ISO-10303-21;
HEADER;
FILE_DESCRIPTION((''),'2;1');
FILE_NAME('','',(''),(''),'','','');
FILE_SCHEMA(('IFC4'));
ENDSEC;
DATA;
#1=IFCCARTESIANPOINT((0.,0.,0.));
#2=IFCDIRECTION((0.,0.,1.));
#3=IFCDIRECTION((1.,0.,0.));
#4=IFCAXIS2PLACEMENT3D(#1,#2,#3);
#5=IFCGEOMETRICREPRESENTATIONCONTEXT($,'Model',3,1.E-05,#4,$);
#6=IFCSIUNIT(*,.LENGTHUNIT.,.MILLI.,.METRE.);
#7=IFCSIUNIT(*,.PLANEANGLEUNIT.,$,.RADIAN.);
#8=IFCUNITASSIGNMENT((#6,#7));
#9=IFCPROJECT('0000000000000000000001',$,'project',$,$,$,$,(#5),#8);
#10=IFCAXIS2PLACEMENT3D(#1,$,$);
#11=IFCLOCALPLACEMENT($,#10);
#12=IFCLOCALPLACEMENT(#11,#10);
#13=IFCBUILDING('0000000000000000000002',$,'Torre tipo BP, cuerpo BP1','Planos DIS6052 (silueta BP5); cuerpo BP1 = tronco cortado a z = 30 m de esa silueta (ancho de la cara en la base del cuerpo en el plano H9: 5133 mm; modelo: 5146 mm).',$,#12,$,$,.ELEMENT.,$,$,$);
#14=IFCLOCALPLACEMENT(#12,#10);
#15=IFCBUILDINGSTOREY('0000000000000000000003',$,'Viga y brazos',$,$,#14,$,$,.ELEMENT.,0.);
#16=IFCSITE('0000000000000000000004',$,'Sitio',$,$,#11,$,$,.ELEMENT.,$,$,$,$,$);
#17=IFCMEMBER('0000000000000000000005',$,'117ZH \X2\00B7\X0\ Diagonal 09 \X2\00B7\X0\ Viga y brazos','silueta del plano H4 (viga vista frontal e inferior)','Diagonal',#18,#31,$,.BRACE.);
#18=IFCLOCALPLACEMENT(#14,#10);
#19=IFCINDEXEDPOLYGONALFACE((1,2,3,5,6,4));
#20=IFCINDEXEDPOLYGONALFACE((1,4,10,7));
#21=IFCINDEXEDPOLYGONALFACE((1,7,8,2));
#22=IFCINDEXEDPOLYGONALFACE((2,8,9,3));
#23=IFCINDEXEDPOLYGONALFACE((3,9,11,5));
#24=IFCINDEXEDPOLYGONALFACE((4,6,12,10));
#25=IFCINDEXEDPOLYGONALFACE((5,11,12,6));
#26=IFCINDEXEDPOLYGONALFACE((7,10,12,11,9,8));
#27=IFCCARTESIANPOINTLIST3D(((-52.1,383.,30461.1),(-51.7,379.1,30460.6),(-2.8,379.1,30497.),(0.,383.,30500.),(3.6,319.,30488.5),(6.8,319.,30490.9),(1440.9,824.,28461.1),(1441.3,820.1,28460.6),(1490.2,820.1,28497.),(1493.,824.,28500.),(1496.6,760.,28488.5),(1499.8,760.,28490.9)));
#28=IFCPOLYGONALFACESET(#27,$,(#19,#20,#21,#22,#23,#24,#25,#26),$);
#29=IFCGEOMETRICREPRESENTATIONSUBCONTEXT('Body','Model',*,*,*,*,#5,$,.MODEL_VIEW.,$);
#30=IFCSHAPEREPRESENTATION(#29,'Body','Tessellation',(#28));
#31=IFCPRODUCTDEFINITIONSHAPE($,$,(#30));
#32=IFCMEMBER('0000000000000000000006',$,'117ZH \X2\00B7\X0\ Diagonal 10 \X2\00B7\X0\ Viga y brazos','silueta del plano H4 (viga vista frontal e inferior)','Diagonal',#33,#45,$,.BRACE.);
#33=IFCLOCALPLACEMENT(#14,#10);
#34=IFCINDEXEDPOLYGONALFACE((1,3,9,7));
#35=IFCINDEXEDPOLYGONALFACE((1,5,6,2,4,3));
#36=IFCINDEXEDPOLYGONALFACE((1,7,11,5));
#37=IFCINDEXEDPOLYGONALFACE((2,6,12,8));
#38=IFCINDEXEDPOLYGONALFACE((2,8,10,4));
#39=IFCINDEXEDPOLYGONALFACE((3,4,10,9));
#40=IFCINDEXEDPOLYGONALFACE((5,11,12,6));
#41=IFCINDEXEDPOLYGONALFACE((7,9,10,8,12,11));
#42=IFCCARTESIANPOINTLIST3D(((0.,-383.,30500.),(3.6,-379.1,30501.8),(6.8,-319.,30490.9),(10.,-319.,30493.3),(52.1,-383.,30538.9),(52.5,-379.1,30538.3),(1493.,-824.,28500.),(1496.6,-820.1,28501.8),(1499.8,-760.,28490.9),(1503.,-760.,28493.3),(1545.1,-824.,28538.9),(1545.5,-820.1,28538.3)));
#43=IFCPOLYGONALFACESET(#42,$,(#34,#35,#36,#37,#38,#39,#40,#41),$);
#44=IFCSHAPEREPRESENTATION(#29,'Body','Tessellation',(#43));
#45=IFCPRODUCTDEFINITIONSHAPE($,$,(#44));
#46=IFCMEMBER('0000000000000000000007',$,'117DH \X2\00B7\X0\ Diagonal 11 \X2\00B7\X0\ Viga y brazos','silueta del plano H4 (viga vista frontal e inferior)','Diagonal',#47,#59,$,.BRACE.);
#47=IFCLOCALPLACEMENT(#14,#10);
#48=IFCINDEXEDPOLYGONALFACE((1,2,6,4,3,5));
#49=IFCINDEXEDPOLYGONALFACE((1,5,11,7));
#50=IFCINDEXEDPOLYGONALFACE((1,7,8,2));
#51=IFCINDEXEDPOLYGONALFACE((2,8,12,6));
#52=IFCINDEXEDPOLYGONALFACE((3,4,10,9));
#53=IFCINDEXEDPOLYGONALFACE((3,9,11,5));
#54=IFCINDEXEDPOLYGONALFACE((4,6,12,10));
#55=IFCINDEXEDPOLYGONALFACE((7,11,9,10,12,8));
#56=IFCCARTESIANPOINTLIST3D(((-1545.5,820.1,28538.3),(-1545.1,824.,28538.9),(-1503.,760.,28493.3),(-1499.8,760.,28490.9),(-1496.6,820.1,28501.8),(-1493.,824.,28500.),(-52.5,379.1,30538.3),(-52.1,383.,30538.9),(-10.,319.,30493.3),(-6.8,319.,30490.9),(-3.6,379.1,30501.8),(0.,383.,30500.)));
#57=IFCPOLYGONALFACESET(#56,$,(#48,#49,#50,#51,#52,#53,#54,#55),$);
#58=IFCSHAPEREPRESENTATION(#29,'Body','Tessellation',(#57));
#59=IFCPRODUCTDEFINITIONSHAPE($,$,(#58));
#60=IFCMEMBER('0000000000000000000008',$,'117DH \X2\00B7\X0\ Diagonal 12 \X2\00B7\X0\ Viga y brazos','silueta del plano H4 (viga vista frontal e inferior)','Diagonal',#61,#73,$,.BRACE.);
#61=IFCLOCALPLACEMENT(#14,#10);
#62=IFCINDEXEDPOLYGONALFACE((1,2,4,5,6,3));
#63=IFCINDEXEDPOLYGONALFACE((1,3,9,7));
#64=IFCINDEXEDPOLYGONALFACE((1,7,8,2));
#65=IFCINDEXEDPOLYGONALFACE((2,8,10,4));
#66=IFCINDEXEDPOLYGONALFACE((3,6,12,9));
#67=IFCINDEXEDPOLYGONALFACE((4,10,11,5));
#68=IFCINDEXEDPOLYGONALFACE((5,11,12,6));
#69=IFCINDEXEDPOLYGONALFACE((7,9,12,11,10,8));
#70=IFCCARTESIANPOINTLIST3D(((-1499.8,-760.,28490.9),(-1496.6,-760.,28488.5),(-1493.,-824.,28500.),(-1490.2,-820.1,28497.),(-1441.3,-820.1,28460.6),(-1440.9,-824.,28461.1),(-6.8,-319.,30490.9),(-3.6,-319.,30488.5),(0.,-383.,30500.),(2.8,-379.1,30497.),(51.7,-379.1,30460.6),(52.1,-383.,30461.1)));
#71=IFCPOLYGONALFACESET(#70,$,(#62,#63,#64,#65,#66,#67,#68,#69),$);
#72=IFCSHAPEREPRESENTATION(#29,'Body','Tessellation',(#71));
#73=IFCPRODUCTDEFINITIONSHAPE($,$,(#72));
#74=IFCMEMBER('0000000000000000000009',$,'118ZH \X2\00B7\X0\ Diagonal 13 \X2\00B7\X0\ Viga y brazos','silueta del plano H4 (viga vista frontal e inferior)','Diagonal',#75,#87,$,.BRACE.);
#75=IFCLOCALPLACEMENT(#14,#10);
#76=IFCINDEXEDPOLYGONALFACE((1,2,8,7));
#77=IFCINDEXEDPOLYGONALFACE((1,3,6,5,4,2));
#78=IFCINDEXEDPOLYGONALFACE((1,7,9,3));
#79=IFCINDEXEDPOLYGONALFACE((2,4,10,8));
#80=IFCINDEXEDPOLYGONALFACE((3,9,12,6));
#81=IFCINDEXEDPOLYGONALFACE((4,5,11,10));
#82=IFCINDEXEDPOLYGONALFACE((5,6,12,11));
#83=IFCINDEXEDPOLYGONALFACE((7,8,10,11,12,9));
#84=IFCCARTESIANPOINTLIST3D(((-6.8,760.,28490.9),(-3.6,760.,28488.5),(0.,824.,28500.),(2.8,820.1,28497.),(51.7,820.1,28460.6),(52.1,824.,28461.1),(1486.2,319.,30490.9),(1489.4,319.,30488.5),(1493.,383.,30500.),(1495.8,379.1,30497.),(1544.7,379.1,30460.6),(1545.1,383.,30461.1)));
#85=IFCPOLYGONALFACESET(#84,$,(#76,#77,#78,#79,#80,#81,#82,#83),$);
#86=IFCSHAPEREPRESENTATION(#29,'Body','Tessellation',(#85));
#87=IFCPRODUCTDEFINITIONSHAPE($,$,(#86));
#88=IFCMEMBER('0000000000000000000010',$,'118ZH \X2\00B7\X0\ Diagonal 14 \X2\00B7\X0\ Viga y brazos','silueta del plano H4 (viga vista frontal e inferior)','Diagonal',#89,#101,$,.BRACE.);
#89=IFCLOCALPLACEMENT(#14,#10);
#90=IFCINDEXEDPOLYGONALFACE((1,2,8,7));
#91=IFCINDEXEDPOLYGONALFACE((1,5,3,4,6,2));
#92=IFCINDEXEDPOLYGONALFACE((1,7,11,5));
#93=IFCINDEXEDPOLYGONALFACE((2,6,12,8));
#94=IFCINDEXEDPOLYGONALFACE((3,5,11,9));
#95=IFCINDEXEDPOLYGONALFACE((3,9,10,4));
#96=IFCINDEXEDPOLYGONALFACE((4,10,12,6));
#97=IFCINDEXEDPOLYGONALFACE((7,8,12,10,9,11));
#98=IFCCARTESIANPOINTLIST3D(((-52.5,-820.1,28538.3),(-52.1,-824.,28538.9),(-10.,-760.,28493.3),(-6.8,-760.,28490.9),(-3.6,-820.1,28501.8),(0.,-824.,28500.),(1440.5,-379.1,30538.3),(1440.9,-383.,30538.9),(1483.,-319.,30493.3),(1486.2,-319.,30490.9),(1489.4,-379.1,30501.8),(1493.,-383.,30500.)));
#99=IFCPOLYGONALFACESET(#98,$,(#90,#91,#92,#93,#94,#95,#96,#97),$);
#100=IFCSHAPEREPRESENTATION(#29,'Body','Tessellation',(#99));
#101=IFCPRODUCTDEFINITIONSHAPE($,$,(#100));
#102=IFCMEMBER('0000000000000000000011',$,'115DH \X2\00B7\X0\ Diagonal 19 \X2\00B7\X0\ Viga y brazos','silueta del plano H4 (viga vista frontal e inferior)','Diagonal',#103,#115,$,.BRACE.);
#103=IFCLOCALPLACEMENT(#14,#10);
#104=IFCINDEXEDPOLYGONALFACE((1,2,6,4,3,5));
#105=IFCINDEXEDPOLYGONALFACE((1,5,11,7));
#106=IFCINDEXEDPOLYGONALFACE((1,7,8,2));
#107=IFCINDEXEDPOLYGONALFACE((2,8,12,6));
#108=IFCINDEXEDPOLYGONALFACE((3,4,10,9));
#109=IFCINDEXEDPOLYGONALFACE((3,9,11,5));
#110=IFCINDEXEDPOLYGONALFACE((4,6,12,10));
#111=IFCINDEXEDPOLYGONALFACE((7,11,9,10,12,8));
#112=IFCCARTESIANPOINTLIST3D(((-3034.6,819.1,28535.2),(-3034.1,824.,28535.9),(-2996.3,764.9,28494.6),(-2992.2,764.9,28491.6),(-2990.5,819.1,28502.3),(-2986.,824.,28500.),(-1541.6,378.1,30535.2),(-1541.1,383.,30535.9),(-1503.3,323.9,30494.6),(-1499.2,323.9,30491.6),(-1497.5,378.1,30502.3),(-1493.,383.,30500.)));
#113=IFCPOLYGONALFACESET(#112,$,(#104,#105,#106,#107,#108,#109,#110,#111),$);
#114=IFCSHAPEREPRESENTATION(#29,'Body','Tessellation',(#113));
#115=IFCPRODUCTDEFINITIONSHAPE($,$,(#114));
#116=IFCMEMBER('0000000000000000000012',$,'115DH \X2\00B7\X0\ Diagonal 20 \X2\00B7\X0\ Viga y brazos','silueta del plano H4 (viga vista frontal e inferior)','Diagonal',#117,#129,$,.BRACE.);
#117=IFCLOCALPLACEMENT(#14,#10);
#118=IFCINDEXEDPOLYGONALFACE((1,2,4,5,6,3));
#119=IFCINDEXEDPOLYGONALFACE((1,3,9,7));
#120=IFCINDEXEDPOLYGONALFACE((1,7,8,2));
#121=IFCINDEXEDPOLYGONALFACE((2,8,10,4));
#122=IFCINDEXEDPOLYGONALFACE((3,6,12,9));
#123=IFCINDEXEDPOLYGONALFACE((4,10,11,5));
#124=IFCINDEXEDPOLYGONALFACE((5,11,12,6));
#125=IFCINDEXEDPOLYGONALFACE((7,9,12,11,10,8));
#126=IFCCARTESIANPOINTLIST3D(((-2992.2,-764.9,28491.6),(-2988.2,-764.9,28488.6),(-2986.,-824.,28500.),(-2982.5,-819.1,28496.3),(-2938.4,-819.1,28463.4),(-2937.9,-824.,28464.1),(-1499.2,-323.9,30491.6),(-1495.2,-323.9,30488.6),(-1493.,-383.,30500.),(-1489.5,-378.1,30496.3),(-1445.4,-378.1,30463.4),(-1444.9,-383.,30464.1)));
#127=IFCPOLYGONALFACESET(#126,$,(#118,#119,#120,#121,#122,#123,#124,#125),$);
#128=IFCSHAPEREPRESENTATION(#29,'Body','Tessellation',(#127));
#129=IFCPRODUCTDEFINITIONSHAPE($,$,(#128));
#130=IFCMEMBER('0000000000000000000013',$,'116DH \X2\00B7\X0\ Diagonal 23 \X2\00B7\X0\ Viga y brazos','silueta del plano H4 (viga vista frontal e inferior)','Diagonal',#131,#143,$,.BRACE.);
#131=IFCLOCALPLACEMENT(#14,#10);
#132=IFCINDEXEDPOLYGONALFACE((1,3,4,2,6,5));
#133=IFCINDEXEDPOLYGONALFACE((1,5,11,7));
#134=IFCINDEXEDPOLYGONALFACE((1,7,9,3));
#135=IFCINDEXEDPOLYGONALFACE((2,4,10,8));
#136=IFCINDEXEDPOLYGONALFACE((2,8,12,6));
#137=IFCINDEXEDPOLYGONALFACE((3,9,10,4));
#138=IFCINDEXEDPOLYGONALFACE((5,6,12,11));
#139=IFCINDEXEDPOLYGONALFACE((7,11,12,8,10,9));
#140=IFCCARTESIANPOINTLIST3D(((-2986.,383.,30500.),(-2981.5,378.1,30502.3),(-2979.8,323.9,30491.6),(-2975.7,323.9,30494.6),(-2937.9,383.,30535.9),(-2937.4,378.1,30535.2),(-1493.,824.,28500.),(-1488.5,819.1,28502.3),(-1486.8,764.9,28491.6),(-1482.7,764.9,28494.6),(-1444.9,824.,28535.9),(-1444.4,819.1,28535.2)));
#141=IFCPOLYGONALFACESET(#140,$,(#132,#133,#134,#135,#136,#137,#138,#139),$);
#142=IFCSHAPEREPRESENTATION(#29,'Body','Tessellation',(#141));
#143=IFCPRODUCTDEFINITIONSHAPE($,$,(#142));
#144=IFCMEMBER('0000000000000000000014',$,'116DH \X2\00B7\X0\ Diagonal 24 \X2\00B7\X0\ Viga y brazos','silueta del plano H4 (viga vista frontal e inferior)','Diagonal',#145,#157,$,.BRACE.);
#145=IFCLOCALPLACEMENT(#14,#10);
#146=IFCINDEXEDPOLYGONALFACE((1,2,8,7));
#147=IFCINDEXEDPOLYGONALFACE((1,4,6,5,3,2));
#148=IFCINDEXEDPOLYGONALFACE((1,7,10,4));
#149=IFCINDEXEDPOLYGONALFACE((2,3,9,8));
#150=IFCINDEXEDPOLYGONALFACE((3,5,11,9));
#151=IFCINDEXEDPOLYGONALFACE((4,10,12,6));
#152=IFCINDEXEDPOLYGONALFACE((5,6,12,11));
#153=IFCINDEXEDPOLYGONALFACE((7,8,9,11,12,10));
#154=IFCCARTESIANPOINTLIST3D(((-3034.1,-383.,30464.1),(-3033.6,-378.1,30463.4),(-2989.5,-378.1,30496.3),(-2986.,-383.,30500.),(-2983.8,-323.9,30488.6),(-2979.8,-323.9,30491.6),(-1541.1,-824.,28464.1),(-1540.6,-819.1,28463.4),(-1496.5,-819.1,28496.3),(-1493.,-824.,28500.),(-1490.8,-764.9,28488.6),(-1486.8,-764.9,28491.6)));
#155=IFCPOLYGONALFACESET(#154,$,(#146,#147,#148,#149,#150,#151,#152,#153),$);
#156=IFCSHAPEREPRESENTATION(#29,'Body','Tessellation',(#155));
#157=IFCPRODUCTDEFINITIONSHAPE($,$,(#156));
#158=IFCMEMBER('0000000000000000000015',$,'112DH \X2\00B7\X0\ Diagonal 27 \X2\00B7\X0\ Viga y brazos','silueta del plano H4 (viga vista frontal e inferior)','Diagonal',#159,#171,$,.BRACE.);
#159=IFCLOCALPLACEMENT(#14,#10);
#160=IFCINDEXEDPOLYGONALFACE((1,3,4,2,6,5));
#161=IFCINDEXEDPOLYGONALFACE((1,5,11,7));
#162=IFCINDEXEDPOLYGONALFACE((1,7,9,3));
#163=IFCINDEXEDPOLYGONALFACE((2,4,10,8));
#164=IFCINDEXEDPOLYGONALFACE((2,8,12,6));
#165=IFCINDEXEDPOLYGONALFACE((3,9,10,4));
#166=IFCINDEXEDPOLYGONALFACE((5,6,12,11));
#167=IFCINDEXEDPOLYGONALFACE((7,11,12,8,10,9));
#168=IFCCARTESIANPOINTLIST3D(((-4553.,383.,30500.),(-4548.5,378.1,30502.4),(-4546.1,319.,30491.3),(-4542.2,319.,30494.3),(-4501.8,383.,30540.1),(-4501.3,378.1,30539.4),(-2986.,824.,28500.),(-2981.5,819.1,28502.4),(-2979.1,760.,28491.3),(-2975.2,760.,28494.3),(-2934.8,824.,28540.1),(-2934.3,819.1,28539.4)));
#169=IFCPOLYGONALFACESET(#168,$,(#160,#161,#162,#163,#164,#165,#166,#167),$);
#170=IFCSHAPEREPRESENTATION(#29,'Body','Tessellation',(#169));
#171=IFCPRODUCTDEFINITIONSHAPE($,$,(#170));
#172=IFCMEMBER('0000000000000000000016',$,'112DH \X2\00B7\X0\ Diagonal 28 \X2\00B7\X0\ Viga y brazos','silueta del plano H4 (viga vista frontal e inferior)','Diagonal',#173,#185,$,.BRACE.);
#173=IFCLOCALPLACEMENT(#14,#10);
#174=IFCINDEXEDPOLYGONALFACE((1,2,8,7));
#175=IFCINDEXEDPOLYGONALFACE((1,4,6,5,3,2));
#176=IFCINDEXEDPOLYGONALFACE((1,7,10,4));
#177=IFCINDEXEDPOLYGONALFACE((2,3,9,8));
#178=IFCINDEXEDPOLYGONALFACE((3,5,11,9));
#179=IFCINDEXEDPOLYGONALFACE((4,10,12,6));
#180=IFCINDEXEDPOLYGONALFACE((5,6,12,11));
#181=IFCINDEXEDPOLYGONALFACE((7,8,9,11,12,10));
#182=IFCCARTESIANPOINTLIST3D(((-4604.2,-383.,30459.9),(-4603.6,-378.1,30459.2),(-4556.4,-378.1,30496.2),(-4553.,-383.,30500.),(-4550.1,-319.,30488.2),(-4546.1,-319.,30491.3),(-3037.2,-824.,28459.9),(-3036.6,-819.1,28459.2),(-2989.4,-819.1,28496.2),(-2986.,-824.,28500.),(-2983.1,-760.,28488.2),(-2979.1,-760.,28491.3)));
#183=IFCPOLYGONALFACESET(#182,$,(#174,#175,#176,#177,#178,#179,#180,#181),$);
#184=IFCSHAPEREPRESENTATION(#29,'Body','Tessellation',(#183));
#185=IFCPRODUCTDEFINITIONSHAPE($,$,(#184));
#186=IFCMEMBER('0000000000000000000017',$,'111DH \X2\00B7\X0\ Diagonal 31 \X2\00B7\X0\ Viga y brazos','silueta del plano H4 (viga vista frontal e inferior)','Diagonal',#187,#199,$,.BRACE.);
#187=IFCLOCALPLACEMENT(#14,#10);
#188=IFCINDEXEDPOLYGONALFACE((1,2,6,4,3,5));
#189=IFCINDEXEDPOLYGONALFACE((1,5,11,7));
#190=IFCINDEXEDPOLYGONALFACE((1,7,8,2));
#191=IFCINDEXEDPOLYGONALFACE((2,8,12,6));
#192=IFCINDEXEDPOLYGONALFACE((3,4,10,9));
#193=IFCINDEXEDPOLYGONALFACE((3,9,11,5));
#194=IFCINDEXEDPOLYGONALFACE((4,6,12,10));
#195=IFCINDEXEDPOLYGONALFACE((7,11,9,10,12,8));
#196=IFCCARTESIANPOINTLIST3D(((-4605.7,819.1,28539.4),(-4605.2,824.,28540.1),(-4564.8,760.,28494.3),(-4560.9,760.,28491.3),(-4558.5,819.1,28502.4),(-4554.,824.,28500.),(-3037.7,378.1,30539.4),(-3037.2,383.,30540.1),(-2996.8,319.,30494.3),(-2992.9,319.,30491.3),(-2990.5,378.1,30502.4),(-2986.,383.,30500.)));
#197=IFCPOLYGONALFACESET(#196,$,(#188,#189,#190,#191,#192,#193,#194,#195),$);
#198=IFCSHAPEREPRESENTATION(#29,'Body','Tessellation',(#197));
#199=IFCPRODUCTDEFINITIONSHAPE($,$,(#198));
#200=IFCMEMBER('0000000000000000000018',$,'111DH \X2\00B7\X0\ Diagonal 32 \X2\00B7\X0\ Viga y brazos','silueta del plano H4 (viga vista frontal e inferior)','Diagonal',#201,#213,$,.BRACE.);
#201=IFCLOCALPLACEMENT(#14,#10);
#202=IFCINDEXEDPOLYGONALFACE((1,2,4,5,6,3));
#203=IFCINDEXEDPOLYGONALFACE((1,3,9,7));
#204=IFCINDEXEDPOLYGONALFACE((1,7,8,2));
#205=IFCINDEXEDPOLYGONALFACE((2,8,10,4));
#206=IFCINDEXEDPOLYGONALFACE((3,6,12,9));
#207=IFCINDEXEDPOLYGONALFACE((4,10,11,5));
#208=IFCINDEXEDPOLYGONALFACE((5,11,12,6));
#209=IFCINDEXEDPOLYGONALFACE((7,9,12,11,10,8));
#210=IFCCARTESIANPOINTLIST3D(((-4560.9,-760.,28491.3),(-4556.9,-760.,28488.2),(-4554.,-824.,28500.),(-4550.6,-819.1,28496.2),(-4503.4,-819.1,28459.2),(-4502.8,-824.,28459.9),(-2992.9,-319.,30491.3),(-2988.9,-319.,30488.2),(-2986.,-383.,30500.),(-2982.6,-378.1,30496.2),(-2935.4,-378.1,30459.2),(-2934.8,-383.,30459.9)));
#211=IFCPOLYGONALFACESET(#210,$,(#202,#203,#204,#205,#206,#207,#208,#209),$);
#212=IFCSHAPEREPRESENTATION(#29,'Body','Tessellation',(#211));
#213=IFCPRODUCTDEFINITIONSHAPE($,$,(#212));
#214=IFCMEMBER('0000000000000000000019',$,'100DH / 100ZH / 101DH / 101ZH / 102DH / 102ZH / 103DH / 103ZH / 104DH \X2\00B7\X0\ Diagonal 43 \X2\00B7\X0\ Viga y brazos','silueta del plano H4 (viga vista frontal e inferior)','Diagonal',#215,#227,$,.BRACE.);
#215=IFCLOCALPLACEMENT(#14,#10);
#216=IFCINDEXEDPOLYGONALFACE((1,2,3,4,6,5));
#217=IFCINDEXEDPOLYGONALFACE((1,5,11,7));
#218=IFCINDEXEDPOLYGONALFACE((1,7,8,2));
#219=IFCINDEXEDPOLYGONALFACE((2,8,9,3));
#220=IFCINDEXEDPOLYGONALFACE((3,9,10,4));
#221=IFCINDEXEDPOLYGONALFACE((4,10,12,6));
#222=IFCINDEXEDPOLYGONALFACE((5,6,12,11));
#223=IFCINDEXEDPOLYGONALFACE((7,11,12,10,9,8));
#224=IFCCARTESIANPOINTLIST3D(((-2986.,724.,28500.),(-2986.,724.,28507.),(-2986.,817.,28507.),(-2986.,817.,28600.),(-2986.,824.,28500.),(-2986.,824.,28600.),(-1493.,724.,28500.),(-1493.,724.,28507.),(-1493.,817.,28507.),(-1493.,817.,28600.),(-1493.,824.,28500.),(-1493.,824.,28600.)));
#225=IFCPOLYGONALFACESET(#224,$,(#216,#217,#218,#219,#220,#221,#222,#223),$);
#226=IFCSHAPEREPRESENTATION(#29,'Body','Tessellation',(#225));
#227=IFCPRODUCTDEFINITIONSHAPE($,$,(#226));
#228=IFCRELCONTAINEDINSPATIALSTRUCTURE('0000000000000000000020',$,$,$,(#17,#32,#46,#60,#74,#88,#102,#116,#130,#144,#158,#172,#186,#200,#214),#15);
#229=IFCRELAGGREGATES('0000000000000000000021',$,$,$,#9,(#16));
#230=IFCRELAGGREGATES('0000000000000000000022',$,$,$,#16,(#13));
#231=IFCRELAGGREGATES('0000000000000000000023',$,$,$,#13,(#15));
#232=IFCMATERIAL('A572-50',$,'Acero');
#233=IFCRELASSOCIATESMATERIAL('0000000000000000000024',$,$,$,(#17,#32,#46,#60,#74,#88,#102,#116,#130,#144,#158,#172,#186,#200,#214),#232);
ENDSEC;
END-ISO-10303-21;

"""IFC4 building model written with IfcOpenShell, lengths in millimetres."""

from ifc_helpers import new_model, si_unit, frame, frame_2d, origin, origin_with_axes, place, context, subcontext, project, spatial, l_section, extrude, material, element, save


model = new_model("IFC4")

# Units and contexts
model_context = context("Model", 3, precision=1e-05, world=origin_with_axes())
body_context = subcontext(model_context, "Body", "Model", "MODEL_VIEW")
ifc_project = project(units=[si_unit("LENGTHUNIT", "METRE", prefix="MILLI"), si_unit("PLANEANGLEUNIT", "RADIAN")], contexts=[model_context])

# Site, building, storey
site_placement = place(None, origin())
site = spatial("IfcSite", under=ifc_project, at=site_placement, Name="Sitio", CompositionType="ELEMENT")
building_placement = place(site_placement, origin())
building = spatial("IfcBuilding", under=site, at=building_placement, Name="Torre tipo BP, cuerpo BP1", Description="Planos DIS6052 (silueta BP5); cuerpo BP1 = tronco cortado a z = 30 m de esa silueta (ancho de la cara en la base del cuerpo en el plano H9: 5133 mm; modelo: 5146 mm).", CompositionType="ELEMENT")
storey_placement = place(building_placement, origin())
storey = spatial("IfcBuildingStorey", under=building, at=storey_placement, Name="Viga y brazos", CompositionType="ELEMENT", Elevation=0.0)

# Members
ifc_material_1 = material(Name="A572-50", Category="Acero")
for number, where, z_axis, x_axis, name in (
    (1, (0.0, 383.0, 30500.0), (0.589078, 0.174001, -0.78912), (0.104088, -0.984745, -0.139435), "117ZH · Diagonal 09 · Viga y brazos"),
    (2, (0.0, -383.0, 30500.0), (0.589078, -0.174001, -0.78912), (0.104088, 0.984745, -0.139435), "117ZH · Diagonal 10 · Viga y brazos"),
    (3, (0.0, 383.0, 30500.0), (-0.589078, 0.174001, -0.78912), (-0.104088, -0.984745, -0.139435), "117DH · Diagonal 11 · Viga y brazos"),
    (4, (0.0, -383.0, 30500.0), (-0.589078, -0.174001, -0.78912), (-0.104088, 0.984745, -0.139435), "117DH · Diagonal 12 · Viga y brazos"),
    (5, (0.0, 824.0, 28500.0), (0.589078, -0.174001, 0.78912), (-0.104088, -0.984745, -0.139435), "118ZH · Diagonal 13 · Viga y brazos"),
    (6, (0.0, -824.0, 28500.0), (0.589078, 0.174001, 0.78912), (-0.104088, 0.984745, -0.139435), "118ZH · Diagonal 14 · Viga y brazos"),
):
    element("IfcMember", number, at=place(storey_placement, frame(where, z_axis=z_axis, x_axis=x_axis)), inside=storey, material=ifc_material_1, Name=name, Description="silueta del plano H4 (viga vista frontal e inferior)", ObjectType="Diagonal", PredefinedType="BRACE", context=body_context, shape_type="SweptSolid", body=[
        extrude(l_section(Depth=65.0, Width=65.0, Thickness=4.0, at=frame_2d((32.5, 32.5))), None, (0.0, 0.0, 1.0), 2534.5),
    ])
for number, where, z_axis, x_axis, name in (
    (7, (-1493.0, 383.0, 30500.0), (-0.589078, 0.174001, -0.78912), (-0.104088, -0.984745, -0.139435), "115DH · Diagonal 19 · Viga y brazos"),
    (8, (-1493.0, -383.0, 30500.0), (-0.589078, -0.174001, -0.78912), (-0.104088, 0.984745, -0.139435), "115DH · Diagonal 20 · Viga y brazos"),
    (9, (-1493.0, 824.0, 28500.0), (-0.589078, -0.174001, 0.78912), (0.104088, -0.984745, -0.139435), "116DH · Diagonal 23 · Viga y brazos"),
    (10, (-1493.0, -824.0, 28500.0), (-0.589078, 0.174001, 0.78912), (0.104088, 0.984745, -0.139435), "116DH · Diagonal 24 · Viga y brazos"),
):
    element("IfcMember", number, at=place(storey_placement, frame(where, z_axis=z_axis, x_axis=x_axis)), inside=storey, material=ifc_material_1, Name=name, Description="silueta del plano H4 (viga vista frontal e inferior)", ObjectType="Diagonal", PredefinedType="BRACE", context=body_context, shape_type="SweptSolid", body=[
        extrude(l_section(Depth=60.0, Width=60.0, Thickness=5.0, at=frame_2d((30.0, 30.0))), None, (0.0, 0.0, 1.0), 2534.5),
    ])
for number, where, z_axis, x_axis, name in (
    (11, (-2986.0, 824.0, 28500.0), (-0.607658, -0.171013, 0.775568), (0.105471, -0.985269, -0.134615), "112DH · Diagonal 27 · Viga y brazos"),
    (12, (-2986.0, -824.0, 28500.0), (-0.607658, 0.171013, 0.775568), (0.105471, 0.985269, -0.134615), "112DH · Diagonal 28 · Viga y brazos"),
):
    element("IfcMember", number, at=place(storey_placement, frame(where, z_axis=z_axis, x_axis=x_axis)), inside=storey, material=ifc_material_1, Name=name, Description="silueta del plano H4 (viga vista frontal e inferior)", ObjectType="Diagonal", PredefinedType="BRACE", context=body_context, shape_type="SweptSolid", body=[
        extrude(l_section(Depth=65.0, Width=65.0, Thickness=5.0, at=frame_2d((32.5, 32.5))), None, (0.0, 0.0, 1.0), 2578.8),
    ])
for number, where, z_axis, x_axis, name in (
    (13, (-2986.0, 383.0, 30500.0), (-0.607902, 0.170973, -0.775386), (-0.105488, -0.985276, -0.134551), "111DH · Diagonal 31 · Viga y brazos"),
    (14, (-2986.0, -383.0, 30500.0), (-0.607902, -0.170973, -0.775386), (-0.105488, 0.985276, -0.134551), "111DH · Diagonal 32 · Viga y brazos"),
):
    element("IfcMember", number, at=place(storey_placement, frame(where, z_axis=z_axis, x_axis=x_axis)), inside=storey, material=ifc_material_1, Name=name, Description="silueta del plano H4 (viga vista frontal e inferior)", ObjectType="Diagonal", PredefinedType="BRACE", context=body_context, shape_type="SweptSolid", body=[
        extrude(l_section(Depth=65.0, Width=65.0, Thickness=5.0, at=frame_2d((32.5, 32.5))), None, (0.0, 0.0, 1.0), 2579.4),
    ])
for number, where, z_axis, x_axis, name in (
    (15, (-1493.0, 824.0, 28500.0), (-1.0, 0.0, 0.0), (0.0, -1.0, 0.0), "100DH / 100ZH / 101DH / 101ZH / 102DH / 102ZH / 103DH / 103ZH / 104DH · Diagonal 43 · Viga y brazos"),
):
    element("IfcMember", number, at=place(storey_placement, frame(where, z_axis=z_axis, x_axis=x_axis)), inside=storey, material=ifc_material_1, Name=name, Description="silueta del plano H4 (viga vista frontal e inferior)", ObjectType="Diagonal", PredefinedType="BRACE", context=body_context, shape_type="SweptSolid", body=[
        extrude(l_section(Depth=100.0, Width=100.0, Thickness=7.0, at=frame_2d((50.0, 50.0))), None, (0.0, 0.0, 1.0), 1493.0),
    ])

save(model, "model.ifc")
